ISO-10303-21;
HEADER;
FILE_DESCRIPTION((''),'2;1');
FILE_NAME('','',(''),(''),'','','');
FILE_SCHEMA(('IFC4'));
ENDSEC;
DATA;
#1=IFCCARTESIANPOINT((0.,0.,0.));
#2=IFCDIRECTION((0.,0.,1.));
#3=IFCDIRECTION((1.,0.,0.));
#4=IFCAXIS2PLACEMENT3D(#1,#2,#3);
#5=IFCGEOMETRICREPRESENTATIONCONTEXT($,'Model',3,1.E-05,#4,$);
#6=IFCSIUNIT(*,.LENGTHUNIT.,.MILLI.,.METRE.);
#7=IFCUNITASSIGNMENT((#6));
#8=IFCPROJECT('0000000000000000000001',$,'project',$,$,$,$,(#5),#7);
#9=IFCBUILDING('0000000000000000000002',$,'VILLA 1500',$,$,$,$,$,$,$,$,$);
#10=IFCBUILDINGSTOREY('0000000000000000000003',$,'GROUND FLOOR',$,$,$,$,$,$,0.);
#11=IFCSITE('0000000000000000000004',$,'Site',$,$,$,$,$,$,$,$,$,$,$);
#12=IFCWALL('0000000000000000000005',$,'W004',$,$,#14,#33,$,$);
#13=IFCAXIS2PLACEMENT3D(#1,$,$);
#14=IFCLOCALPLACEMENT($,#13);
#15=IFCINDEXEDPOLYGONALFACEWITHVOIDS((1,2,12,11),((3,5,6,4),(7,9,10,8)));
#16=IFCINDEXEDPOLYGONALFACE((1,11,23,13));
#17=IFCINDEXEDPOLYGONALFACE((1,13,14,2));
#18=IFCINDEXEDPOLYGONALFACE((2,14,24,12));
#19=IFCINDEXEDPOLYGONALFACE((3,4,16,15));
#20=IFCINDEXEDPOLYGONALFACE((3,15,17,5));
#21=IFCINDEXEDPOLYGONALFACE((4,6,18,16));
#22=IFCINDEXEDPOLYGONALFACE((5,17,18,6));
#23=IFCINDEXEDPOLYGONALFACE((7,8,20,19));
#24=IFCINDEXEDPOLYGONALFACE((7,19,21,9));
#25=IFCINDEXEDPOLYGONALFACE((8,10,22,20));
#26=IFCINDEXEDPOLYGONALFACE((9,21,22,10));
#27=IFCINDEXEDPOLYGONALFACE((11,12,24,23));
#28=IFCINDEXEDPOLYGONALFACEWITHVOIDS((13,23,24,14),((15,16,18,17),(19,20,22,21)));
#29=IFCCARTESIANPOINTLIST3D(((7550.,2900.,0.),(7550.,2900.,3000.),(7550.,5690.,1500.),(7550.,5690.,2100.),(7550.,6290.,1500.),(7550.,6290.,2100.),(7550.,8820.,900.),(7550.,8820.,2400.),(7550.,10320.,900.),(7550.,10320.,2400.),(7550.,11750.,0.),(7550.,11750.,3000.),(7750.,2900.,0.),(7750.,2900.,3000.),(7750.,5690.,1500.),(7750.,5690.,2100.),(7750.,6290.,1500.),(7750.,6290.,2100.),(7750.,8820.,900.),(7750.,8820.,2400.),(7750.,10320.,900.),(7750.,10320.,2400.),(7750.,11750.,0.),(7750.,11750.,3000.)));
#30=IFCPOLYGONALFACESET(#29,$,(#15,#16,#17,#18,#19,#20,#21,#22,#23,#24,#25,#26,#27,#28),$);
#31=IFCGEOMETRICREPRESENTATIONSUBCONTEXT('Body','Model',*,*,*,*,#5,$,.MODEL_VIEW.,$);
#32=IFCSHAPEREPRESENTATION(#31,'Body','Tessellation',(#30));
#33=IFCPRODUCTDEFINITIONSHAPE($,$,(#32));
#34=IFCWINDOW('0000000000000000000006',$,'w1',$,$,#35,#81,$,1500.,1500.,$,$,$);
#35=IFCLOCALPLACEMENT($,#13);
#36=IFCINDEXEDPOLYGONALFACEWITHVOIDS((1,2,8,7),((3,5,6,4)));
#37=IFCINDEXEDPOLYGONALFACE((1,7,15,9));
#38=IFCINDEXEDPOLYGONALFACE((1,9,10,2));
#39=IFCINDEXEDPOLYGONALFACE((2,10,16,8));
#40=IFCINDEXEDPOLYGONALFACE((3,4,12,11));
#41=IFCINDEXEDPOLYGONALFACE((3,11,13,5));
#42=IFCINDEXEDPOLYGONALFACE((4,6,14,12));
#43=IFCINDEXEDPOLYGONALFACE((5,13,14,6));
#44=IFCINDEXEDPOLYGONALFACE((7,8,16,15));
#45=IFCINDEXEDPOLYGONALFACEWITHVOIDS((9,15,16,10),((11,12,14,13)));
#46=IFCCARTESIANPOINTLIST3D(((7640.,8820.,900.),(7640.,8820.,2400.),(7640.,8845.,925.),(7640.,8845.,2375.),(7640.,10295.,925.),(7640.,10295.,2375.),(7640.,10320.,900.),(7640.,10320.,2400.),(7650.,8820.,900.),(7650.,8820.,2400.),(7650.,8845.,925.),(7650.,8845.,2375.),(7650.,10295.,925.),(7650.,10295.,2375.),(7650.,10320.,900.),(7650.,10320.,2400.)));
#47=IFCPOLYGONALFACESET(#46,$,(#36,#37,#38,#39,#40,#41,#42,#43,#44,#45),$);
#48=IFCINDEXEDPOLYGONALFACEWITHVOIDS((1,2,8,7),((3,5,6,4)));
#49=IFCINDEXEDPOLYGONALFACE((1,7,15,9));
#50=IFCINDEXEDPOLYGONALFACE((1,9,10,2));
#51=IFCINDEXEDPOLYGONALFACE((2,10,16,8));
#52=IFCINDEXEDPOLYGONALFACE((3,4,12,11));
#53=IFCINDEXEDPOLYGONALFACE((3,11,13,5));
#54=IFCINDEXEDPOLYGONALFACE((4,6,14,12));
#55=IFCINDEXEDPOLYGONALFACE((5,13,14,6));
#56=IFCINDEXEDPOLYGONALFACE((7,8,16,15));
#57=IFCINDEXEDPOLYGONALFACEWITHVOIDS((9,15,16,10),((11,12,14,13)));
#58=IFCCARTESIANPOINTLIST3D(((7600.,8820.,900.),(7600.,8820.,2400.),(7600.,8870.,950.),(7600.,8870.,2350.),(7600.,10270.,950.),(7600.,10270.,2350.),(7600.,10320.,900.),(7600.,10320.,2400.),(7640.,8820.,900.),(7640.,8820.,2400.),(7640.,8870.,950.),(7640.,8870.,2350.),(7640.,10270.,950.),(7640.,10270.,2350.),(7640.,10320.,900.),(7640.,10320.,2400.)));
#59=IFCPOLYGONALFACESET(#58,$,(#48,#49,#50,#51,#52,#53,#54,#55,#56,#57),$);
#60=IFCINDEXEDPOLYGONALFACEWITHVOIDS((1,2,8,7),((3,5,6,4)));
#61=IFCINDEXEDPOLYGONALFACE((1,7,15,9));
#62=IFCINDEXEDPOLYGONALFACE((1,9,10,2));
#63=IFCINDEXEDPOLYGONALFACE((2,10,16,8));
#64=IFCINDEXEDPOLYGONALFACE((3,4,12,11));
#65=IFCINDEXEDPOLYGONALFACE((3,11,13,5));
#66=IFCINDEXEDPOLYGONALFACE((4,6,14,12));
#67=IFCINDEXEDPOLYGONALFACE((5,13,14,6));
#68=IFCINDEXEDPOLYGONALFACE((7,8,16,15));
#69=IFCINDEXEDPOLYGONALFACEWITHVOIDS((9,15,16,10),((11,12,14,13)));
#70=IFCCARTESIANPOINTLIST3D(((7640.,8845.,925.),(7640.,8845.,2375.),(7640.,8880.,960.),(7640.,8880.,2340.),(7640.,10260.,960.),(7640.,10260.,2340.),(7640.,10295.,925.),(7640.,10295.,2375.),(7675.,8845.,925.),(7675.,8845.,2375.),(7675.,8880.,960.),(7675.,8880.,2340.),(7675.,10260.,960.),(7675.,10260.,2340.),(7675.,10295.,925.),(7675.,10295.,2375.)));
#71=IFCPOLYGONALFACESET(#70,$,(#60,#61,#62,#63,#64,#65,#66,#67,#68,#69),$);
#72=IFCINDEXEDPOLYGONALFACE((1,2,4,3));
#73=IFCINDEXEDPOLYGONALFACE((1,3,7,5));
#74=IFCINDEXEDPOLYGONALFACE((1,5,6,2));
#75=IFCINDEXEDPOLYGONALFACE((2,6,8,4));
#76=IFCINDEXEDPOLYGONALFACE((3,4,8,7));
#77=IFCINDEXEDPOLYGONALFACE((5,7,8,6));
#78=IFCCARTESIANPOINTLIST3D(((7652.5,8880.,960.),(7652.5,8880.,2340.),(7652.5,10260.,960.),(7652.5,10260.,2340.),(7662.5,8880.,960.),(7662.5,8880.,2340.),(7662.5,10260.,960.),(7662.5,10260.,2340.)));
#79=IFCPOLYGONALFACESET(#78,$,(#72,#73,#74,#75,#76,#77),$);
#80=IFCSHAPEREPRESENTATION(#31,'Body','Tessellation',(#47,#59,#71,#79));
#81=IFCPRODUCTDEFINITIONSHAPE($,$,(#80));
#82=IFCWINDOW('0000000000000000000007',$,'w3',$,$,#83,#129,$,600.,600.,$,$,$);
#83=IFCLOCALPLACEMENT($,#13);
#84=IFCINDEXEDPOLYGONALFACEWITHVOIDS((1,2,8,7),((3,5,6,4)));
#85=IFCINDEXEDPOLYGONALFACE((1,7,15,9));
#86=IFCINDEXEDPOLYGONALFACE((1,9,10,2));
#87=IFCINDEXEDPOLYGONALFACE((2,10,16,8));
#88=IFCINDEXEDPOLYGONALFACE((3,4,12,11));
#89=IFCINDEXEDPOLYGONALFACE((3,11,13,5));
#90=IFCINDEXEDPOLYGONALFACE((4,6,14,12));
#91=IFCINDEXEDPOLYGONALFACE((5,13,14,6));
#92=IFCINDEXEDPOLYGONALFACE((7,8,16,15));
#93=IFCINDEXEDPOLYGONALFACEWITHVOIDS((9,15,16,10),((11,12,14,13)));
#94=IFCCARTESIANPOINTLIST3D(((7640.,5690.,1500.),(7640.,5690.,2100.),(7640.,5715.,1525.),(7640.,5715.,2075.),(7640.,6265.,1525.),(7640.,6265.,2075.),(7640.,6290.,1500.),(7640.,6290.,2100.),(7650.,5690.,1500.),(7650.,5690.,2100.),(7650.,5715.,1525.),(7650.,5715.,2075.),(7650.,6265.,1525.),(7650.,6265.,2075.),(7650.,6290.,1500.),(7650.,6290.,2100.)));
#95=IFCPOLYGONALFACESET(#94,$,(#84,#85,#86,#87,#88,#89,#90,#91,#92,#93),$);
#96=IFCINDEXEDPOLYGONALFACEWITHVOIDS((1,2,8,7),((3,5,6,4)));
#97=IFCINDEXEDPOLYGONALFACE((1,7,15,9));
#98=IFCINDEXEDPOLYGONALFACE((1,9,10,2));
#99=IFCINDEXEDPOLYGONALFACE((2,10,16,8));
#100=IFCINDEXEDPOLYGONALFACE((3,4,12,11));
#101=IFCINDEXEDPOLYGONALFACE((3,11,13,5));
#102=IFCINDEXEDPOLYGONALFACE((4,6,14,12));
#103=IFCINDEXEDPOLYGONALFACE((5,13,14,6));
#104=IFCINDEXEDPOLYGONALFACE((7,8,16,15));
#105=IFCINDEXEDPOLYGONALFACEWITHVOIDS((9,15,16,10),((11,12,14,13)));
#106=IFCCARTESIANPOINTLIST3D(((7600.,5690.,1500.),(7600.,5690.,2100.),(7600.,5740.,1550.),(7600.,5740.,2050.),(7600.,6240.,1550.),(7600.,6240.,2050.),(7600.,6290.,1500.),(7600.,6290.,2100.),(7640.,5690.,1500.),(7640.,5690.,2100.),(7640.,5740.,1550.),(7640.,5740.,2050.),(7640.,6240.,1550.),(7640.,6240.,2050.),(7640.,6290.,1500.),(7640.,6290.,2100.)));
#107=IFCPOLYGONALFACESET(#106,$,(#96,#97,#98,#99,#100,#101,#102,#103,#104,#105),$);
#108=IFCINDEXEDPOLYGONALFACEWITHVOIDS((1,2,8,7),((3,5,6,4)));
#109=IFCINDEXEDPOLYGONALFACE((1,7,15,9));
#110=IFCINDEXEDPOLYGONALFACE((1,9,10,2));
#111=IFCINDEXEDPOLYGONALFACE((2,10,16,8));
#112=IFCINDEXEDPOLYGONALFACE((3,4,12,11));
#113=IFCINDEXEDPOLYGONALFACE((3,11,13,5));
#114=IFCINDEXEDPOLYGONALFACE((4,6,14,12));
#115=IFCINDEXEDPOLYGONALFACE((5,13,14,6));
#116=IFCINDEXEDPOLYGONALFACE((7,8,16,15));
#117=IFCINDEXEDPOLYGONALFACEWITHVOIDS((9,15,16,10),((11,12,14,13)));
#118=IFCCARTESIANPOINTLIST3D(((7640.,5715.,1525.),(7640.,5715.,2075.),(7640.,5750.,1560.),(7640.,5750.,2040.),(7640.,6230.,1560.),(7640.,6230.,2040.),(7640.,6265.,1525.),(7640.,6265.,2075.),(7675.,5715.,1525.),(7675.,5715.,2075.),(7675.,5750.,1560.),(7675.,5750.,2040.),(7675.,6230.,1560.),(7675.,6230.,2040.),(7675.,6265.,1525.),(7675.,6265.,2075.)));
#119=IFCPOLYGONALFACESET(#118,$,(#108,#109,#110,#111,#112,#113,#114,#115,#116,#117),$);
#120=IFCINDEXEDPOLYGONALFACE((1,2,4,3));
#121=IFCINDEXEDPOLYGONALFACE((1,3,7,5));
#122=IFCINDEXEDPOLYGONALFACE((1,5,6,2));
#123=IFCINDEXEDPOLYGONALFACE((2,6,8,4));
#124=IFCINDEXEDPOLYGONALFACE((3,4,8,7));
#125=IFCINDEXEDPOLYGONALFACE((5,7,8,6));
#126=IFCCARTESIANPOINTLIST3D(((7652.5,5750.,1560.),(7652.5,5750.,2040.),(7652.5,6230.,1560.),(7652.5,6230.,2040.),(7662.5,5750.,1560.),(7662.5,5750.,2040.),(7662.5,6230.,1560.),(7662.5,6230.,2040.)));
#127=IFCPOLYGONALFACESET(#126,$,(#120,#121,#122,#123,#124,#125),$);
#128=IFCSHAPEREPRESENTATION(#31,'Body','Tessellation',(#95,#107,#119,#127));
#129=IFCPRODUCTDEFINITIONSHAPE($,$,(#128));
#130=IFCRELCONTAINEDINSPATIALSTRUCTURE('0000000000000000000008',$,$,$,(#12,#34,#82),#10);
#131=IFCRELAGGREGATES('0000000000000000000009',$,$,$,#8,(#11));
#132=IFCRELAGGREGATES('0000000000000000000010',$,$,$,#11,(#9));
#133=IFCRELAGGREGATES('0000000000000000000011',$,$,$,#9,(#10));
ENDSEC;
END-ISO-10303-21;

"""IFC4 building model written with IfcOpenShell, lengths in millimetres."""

from ifc_helpers import new_model, si_unit, frame, origin_with_axes, place, context, subcontext, project, spatial, line, indexed_curve, outline, extrude, element, fill, save


model = new_model("IFC4")

# Units and contexts
model_context = context("Model", 3, precision=1e-05, world=origin_with_axes())
body_context = subcontext(model_context, "Body", "Model", "MODEL_VIEW")
ifc_project = project(units=[si_unit("LENGTHUNIT", "METRE", prefix="MILLI")], contexts=[model_context])

# Site, building, storey
site = spatial("IfcSite", under=ifc_project, Name="Site")
building = spatial("IfcBuilding", under=site, Name="VILLA 1500")
storey = spatial("IfcBuildingStorey", under=building, Name="GROUND FLOOR", Elevation=0.0)

# Wall, openings, windows
wall_1_placement = place(None, frame((7650.0, 11750.0, 0.0), z_axis=(0.0, 0.0, 1.0), x_axis=(0.0, -1.0, 0.0)))
wall_1 = element("IfcWall", 1, at=wall_1_placement, inside=storey, Name="W004", context=body_context, shape_type="SweptSolid", body=[
    extrude(outline(indexed_curve([(0.0, 0.0), (0.0, 200.0), (8850.0, 200.0), (8850.0, 0.0), (0.0, 0.0)], self_intersect=False)), frame((0.0, -100.0, 0.0), z_axis=(0.0, 0.0, 1.0), x_axis=(1.0, 0.0, 0.0)), (0.0, 0.0, 1.0), 3000.0),
])
opening_1_placement = place(wall_1_placement, frame((1430.0, 0.0, 900.0), z_axis=(0.0, 0.0, 1.0), x_axis=(1.0, 0.0, 0.0)))
opening_1 = element("IfcOpeningElement", 2, at=opening_1_placement, cuts=wall_1, context=body_context, shape_type="SweptSolid", body=[
    extrude(outline(indexed_curve([(0.0, 0.0), (0.0, 300.0), (1500.0, 300.0), (1500.0, 0.0), (0.0, 0.0)], self_intersect=False)), frame((0.0, -150.0, 0.0), z_axis=(0.0, 0.0, 1.0), x_axis=(1.0, 0.0, 0.0)), (0.0, 0.0, 1.0), 1500.0),
])
opening_2_placement = place(wall_1_placement, frame((5460.0, 0.0, 1500.0), z_axis=(0.0, 0.0, 1.0), x_axis=(1.0, 0.0, 0.0)))
opening_2 = element("IfcOpeningElement", 3, at=opening_2_placement, cuts=wall_1, context=body_context, shape_type="SweptSolid", body=[
    extrude(outline(indexed_curve([(0.0, 0.0), (0.0, 300.0), (600.0, 300.0), (600.0, 0.0), (0.0, 0.0)], self_intersect=False)), frame((0.0, -150.0, 0.0), z_axis=(0.0, 0.0, 1.0), x_axis=(1.0, 0.0, 0.0)), (0.0, 0.0, 1.0), 600.0),
])
window_1_placement = place(None, frame((7550.0, 10320.0, 900.0), z_axis=(0.0, 0.0, 1.0), x_axis=(0.0, -1.0, 0.0)))
window_1 = element("IfcWindow", 4, at=window_1_placement, inside=storey, Name="w1", OverallHeight=1500.0, OverallWidth=1500.0, context=body_context, shape_type="SweptSolid", body=[
    extrude(outline(indexed_curve([(0.0, 0.0), (1500.0, 0.0), (1500.0, 1500.0), (0.0, 1500.0)], segments=[line(1, 2, 3, 4, 1)]), holes=[indexed_curve([(25.0, 25.0), (1475.0, 25.0), (1475.0, 1475.0), (25.0, 1475.0)], segments=[line(1, 2, 3, 4, 1)])]), frame((0.0, 90.0, 0.0), z_axis=(0.0, -1.0, 0.0), x_axis=(1.0, 0.0, 0.0)), (0.0, 0.0, -1.0), 10.0),
    extrude(outline(indexed_curve([(0.0, 0.0), (1500.0, 0.0), (1500.0, 1500.0), (0.0, 1500.0)], segments=[line(1, 2, 3, 4, 1)]), holes=[indexed_curve([(50.0, 50.0), (1450.0, 50.0), (1450.0, 1450.0), (50.0, 1450.0)], segments=[line(1, 2, 3, 4, 1)])]), frame((0.0, 50.0, 0.0), z_axis=(0.0, -1.0, 0.0), x_axis=(1.0, 0.0, 0.0)), (0.0, 0.0, -1.0), 40.0),
    extrude(outline(indexed_curve([(0.0, 0.0), (1450.0, 0.0), (1450.0, 1450.0), (0.0, 1450.0)], segments=[line(1, 2, 3, 4, 1)]), holes=[indexed_curve([(35.0, 35.0), (1415.0, 35.0), (1415.0, 1415.0), (35.0, 1415.0)], segments=[line(1, 2, 3, 4, 1)])]), frame((25.0, 90.0, 25.0), z_axis=(0.0, -1.0, 0.0), x_axis=(1.0, 0.0, 0.0)), (0.0, 0.0, -1.0), 35.0),
    extrude(outline(indexed_curve([(35.0, 35.0), (1415.0, 35.0), (1415.0, 1415.0), (35.0, 1415.0)], segments=[line(1, 2, 3, 4, 1)])), frame((25.0, 102.5, 25.0), z_axis=(0.0, -1.0, 0.0), x_axis=(1.0, 0.0, 0.0)), (0.0, 0.0, -1.0), 10.0),
])
fill(opening_1, window_1)
window_2_placement = place(None, frame((7550.0, 6290.0, 1500.0), z_axis=(0.0, 0.0, 1.0), x_axis=(0.0, -1.0, 0.0)))
window_2 = element("IfcWindow", 5, at=window_2_placement, inside=storey, Name="w3", OverallHeight=600.0, OverallWidth=600.0, context=body_context, shape_type="SweptSolid", body=[
    extrude(outline(indexed_curve([(0.0, 0.0), (600.0, 0.0), (600.0, 600.0), (0.0, 600.0)], segments=[line(1, 2, 3, 4, 1)]), holes=[indexed_curve([(25.0, 25.0), (575.0, 25.0), (575.0, 575.0), (25.0, 575.0)], segments=[line(1, 2, 3, 4, 1)])]), frame((0.0, 90.0, 0.0), z_axis=(0.0, -1.0, 0.0), x_axis=(1.0, 0.0, 0.0)), (0.0, 0.0, -1.0), 10.0),
    extrude(outline(indexed_curve([(0.0, 0.0), (600.0, 0.0), (600.0, 600.0), (0.0, 600.0)], segments=[line(1, 2, 3, 4, 1)]), holes=[indexed_curve([(50.0, 50.0), (550.0, 50.0), (550.0, 550.0), (50.0, 550.0)], segments=[line(1, 2, 3, 4, 1)])]), frame((0.0, 50.0, 0.0), z_axis=(0.0, -1.0, 0.0), x_axis=(1.0, 0.0, 0.0)), (0.0, 0.0, -1.0), 40.0),
    extrude(outline(indexed_curve([(0.0, 0.0), (550.0, 0.0), (550.0, 550.0), (0.0, 550.0)], segments=[line(1, 2, 3, 4, 1)]), holes=[indexed_curve([(35.0, 35.0), (515.0, 35.0), (515.0, 515.0), (35.0, 515.0)], segments=[line(1, 2, 3, 4, 1)])]), frame((25.0, 90.0, 25.0), z_axis=(0.0, -1.0, 0.0), x_axis=(1.0, 0.0, 0.0)), (0.0, 0.0, -1.0), 35.0),
    extrude(outline(indexed_curve([(35.0, 35.0), (515.0, 35.0), (515.0, 515.0), (35.0, 515.0)], segments=[line(1, 2, 3, 4, 1)])), frame((25.0, 102.5, 25.0), z_axis=(0.0, -1.0, 0.0), x_axis=(1.0, 0.0, 0.0)), (0.0, 0.0, -1.0), 10.0),
])
fill(opening_2, window_2)

save(model, "model.ifc")
